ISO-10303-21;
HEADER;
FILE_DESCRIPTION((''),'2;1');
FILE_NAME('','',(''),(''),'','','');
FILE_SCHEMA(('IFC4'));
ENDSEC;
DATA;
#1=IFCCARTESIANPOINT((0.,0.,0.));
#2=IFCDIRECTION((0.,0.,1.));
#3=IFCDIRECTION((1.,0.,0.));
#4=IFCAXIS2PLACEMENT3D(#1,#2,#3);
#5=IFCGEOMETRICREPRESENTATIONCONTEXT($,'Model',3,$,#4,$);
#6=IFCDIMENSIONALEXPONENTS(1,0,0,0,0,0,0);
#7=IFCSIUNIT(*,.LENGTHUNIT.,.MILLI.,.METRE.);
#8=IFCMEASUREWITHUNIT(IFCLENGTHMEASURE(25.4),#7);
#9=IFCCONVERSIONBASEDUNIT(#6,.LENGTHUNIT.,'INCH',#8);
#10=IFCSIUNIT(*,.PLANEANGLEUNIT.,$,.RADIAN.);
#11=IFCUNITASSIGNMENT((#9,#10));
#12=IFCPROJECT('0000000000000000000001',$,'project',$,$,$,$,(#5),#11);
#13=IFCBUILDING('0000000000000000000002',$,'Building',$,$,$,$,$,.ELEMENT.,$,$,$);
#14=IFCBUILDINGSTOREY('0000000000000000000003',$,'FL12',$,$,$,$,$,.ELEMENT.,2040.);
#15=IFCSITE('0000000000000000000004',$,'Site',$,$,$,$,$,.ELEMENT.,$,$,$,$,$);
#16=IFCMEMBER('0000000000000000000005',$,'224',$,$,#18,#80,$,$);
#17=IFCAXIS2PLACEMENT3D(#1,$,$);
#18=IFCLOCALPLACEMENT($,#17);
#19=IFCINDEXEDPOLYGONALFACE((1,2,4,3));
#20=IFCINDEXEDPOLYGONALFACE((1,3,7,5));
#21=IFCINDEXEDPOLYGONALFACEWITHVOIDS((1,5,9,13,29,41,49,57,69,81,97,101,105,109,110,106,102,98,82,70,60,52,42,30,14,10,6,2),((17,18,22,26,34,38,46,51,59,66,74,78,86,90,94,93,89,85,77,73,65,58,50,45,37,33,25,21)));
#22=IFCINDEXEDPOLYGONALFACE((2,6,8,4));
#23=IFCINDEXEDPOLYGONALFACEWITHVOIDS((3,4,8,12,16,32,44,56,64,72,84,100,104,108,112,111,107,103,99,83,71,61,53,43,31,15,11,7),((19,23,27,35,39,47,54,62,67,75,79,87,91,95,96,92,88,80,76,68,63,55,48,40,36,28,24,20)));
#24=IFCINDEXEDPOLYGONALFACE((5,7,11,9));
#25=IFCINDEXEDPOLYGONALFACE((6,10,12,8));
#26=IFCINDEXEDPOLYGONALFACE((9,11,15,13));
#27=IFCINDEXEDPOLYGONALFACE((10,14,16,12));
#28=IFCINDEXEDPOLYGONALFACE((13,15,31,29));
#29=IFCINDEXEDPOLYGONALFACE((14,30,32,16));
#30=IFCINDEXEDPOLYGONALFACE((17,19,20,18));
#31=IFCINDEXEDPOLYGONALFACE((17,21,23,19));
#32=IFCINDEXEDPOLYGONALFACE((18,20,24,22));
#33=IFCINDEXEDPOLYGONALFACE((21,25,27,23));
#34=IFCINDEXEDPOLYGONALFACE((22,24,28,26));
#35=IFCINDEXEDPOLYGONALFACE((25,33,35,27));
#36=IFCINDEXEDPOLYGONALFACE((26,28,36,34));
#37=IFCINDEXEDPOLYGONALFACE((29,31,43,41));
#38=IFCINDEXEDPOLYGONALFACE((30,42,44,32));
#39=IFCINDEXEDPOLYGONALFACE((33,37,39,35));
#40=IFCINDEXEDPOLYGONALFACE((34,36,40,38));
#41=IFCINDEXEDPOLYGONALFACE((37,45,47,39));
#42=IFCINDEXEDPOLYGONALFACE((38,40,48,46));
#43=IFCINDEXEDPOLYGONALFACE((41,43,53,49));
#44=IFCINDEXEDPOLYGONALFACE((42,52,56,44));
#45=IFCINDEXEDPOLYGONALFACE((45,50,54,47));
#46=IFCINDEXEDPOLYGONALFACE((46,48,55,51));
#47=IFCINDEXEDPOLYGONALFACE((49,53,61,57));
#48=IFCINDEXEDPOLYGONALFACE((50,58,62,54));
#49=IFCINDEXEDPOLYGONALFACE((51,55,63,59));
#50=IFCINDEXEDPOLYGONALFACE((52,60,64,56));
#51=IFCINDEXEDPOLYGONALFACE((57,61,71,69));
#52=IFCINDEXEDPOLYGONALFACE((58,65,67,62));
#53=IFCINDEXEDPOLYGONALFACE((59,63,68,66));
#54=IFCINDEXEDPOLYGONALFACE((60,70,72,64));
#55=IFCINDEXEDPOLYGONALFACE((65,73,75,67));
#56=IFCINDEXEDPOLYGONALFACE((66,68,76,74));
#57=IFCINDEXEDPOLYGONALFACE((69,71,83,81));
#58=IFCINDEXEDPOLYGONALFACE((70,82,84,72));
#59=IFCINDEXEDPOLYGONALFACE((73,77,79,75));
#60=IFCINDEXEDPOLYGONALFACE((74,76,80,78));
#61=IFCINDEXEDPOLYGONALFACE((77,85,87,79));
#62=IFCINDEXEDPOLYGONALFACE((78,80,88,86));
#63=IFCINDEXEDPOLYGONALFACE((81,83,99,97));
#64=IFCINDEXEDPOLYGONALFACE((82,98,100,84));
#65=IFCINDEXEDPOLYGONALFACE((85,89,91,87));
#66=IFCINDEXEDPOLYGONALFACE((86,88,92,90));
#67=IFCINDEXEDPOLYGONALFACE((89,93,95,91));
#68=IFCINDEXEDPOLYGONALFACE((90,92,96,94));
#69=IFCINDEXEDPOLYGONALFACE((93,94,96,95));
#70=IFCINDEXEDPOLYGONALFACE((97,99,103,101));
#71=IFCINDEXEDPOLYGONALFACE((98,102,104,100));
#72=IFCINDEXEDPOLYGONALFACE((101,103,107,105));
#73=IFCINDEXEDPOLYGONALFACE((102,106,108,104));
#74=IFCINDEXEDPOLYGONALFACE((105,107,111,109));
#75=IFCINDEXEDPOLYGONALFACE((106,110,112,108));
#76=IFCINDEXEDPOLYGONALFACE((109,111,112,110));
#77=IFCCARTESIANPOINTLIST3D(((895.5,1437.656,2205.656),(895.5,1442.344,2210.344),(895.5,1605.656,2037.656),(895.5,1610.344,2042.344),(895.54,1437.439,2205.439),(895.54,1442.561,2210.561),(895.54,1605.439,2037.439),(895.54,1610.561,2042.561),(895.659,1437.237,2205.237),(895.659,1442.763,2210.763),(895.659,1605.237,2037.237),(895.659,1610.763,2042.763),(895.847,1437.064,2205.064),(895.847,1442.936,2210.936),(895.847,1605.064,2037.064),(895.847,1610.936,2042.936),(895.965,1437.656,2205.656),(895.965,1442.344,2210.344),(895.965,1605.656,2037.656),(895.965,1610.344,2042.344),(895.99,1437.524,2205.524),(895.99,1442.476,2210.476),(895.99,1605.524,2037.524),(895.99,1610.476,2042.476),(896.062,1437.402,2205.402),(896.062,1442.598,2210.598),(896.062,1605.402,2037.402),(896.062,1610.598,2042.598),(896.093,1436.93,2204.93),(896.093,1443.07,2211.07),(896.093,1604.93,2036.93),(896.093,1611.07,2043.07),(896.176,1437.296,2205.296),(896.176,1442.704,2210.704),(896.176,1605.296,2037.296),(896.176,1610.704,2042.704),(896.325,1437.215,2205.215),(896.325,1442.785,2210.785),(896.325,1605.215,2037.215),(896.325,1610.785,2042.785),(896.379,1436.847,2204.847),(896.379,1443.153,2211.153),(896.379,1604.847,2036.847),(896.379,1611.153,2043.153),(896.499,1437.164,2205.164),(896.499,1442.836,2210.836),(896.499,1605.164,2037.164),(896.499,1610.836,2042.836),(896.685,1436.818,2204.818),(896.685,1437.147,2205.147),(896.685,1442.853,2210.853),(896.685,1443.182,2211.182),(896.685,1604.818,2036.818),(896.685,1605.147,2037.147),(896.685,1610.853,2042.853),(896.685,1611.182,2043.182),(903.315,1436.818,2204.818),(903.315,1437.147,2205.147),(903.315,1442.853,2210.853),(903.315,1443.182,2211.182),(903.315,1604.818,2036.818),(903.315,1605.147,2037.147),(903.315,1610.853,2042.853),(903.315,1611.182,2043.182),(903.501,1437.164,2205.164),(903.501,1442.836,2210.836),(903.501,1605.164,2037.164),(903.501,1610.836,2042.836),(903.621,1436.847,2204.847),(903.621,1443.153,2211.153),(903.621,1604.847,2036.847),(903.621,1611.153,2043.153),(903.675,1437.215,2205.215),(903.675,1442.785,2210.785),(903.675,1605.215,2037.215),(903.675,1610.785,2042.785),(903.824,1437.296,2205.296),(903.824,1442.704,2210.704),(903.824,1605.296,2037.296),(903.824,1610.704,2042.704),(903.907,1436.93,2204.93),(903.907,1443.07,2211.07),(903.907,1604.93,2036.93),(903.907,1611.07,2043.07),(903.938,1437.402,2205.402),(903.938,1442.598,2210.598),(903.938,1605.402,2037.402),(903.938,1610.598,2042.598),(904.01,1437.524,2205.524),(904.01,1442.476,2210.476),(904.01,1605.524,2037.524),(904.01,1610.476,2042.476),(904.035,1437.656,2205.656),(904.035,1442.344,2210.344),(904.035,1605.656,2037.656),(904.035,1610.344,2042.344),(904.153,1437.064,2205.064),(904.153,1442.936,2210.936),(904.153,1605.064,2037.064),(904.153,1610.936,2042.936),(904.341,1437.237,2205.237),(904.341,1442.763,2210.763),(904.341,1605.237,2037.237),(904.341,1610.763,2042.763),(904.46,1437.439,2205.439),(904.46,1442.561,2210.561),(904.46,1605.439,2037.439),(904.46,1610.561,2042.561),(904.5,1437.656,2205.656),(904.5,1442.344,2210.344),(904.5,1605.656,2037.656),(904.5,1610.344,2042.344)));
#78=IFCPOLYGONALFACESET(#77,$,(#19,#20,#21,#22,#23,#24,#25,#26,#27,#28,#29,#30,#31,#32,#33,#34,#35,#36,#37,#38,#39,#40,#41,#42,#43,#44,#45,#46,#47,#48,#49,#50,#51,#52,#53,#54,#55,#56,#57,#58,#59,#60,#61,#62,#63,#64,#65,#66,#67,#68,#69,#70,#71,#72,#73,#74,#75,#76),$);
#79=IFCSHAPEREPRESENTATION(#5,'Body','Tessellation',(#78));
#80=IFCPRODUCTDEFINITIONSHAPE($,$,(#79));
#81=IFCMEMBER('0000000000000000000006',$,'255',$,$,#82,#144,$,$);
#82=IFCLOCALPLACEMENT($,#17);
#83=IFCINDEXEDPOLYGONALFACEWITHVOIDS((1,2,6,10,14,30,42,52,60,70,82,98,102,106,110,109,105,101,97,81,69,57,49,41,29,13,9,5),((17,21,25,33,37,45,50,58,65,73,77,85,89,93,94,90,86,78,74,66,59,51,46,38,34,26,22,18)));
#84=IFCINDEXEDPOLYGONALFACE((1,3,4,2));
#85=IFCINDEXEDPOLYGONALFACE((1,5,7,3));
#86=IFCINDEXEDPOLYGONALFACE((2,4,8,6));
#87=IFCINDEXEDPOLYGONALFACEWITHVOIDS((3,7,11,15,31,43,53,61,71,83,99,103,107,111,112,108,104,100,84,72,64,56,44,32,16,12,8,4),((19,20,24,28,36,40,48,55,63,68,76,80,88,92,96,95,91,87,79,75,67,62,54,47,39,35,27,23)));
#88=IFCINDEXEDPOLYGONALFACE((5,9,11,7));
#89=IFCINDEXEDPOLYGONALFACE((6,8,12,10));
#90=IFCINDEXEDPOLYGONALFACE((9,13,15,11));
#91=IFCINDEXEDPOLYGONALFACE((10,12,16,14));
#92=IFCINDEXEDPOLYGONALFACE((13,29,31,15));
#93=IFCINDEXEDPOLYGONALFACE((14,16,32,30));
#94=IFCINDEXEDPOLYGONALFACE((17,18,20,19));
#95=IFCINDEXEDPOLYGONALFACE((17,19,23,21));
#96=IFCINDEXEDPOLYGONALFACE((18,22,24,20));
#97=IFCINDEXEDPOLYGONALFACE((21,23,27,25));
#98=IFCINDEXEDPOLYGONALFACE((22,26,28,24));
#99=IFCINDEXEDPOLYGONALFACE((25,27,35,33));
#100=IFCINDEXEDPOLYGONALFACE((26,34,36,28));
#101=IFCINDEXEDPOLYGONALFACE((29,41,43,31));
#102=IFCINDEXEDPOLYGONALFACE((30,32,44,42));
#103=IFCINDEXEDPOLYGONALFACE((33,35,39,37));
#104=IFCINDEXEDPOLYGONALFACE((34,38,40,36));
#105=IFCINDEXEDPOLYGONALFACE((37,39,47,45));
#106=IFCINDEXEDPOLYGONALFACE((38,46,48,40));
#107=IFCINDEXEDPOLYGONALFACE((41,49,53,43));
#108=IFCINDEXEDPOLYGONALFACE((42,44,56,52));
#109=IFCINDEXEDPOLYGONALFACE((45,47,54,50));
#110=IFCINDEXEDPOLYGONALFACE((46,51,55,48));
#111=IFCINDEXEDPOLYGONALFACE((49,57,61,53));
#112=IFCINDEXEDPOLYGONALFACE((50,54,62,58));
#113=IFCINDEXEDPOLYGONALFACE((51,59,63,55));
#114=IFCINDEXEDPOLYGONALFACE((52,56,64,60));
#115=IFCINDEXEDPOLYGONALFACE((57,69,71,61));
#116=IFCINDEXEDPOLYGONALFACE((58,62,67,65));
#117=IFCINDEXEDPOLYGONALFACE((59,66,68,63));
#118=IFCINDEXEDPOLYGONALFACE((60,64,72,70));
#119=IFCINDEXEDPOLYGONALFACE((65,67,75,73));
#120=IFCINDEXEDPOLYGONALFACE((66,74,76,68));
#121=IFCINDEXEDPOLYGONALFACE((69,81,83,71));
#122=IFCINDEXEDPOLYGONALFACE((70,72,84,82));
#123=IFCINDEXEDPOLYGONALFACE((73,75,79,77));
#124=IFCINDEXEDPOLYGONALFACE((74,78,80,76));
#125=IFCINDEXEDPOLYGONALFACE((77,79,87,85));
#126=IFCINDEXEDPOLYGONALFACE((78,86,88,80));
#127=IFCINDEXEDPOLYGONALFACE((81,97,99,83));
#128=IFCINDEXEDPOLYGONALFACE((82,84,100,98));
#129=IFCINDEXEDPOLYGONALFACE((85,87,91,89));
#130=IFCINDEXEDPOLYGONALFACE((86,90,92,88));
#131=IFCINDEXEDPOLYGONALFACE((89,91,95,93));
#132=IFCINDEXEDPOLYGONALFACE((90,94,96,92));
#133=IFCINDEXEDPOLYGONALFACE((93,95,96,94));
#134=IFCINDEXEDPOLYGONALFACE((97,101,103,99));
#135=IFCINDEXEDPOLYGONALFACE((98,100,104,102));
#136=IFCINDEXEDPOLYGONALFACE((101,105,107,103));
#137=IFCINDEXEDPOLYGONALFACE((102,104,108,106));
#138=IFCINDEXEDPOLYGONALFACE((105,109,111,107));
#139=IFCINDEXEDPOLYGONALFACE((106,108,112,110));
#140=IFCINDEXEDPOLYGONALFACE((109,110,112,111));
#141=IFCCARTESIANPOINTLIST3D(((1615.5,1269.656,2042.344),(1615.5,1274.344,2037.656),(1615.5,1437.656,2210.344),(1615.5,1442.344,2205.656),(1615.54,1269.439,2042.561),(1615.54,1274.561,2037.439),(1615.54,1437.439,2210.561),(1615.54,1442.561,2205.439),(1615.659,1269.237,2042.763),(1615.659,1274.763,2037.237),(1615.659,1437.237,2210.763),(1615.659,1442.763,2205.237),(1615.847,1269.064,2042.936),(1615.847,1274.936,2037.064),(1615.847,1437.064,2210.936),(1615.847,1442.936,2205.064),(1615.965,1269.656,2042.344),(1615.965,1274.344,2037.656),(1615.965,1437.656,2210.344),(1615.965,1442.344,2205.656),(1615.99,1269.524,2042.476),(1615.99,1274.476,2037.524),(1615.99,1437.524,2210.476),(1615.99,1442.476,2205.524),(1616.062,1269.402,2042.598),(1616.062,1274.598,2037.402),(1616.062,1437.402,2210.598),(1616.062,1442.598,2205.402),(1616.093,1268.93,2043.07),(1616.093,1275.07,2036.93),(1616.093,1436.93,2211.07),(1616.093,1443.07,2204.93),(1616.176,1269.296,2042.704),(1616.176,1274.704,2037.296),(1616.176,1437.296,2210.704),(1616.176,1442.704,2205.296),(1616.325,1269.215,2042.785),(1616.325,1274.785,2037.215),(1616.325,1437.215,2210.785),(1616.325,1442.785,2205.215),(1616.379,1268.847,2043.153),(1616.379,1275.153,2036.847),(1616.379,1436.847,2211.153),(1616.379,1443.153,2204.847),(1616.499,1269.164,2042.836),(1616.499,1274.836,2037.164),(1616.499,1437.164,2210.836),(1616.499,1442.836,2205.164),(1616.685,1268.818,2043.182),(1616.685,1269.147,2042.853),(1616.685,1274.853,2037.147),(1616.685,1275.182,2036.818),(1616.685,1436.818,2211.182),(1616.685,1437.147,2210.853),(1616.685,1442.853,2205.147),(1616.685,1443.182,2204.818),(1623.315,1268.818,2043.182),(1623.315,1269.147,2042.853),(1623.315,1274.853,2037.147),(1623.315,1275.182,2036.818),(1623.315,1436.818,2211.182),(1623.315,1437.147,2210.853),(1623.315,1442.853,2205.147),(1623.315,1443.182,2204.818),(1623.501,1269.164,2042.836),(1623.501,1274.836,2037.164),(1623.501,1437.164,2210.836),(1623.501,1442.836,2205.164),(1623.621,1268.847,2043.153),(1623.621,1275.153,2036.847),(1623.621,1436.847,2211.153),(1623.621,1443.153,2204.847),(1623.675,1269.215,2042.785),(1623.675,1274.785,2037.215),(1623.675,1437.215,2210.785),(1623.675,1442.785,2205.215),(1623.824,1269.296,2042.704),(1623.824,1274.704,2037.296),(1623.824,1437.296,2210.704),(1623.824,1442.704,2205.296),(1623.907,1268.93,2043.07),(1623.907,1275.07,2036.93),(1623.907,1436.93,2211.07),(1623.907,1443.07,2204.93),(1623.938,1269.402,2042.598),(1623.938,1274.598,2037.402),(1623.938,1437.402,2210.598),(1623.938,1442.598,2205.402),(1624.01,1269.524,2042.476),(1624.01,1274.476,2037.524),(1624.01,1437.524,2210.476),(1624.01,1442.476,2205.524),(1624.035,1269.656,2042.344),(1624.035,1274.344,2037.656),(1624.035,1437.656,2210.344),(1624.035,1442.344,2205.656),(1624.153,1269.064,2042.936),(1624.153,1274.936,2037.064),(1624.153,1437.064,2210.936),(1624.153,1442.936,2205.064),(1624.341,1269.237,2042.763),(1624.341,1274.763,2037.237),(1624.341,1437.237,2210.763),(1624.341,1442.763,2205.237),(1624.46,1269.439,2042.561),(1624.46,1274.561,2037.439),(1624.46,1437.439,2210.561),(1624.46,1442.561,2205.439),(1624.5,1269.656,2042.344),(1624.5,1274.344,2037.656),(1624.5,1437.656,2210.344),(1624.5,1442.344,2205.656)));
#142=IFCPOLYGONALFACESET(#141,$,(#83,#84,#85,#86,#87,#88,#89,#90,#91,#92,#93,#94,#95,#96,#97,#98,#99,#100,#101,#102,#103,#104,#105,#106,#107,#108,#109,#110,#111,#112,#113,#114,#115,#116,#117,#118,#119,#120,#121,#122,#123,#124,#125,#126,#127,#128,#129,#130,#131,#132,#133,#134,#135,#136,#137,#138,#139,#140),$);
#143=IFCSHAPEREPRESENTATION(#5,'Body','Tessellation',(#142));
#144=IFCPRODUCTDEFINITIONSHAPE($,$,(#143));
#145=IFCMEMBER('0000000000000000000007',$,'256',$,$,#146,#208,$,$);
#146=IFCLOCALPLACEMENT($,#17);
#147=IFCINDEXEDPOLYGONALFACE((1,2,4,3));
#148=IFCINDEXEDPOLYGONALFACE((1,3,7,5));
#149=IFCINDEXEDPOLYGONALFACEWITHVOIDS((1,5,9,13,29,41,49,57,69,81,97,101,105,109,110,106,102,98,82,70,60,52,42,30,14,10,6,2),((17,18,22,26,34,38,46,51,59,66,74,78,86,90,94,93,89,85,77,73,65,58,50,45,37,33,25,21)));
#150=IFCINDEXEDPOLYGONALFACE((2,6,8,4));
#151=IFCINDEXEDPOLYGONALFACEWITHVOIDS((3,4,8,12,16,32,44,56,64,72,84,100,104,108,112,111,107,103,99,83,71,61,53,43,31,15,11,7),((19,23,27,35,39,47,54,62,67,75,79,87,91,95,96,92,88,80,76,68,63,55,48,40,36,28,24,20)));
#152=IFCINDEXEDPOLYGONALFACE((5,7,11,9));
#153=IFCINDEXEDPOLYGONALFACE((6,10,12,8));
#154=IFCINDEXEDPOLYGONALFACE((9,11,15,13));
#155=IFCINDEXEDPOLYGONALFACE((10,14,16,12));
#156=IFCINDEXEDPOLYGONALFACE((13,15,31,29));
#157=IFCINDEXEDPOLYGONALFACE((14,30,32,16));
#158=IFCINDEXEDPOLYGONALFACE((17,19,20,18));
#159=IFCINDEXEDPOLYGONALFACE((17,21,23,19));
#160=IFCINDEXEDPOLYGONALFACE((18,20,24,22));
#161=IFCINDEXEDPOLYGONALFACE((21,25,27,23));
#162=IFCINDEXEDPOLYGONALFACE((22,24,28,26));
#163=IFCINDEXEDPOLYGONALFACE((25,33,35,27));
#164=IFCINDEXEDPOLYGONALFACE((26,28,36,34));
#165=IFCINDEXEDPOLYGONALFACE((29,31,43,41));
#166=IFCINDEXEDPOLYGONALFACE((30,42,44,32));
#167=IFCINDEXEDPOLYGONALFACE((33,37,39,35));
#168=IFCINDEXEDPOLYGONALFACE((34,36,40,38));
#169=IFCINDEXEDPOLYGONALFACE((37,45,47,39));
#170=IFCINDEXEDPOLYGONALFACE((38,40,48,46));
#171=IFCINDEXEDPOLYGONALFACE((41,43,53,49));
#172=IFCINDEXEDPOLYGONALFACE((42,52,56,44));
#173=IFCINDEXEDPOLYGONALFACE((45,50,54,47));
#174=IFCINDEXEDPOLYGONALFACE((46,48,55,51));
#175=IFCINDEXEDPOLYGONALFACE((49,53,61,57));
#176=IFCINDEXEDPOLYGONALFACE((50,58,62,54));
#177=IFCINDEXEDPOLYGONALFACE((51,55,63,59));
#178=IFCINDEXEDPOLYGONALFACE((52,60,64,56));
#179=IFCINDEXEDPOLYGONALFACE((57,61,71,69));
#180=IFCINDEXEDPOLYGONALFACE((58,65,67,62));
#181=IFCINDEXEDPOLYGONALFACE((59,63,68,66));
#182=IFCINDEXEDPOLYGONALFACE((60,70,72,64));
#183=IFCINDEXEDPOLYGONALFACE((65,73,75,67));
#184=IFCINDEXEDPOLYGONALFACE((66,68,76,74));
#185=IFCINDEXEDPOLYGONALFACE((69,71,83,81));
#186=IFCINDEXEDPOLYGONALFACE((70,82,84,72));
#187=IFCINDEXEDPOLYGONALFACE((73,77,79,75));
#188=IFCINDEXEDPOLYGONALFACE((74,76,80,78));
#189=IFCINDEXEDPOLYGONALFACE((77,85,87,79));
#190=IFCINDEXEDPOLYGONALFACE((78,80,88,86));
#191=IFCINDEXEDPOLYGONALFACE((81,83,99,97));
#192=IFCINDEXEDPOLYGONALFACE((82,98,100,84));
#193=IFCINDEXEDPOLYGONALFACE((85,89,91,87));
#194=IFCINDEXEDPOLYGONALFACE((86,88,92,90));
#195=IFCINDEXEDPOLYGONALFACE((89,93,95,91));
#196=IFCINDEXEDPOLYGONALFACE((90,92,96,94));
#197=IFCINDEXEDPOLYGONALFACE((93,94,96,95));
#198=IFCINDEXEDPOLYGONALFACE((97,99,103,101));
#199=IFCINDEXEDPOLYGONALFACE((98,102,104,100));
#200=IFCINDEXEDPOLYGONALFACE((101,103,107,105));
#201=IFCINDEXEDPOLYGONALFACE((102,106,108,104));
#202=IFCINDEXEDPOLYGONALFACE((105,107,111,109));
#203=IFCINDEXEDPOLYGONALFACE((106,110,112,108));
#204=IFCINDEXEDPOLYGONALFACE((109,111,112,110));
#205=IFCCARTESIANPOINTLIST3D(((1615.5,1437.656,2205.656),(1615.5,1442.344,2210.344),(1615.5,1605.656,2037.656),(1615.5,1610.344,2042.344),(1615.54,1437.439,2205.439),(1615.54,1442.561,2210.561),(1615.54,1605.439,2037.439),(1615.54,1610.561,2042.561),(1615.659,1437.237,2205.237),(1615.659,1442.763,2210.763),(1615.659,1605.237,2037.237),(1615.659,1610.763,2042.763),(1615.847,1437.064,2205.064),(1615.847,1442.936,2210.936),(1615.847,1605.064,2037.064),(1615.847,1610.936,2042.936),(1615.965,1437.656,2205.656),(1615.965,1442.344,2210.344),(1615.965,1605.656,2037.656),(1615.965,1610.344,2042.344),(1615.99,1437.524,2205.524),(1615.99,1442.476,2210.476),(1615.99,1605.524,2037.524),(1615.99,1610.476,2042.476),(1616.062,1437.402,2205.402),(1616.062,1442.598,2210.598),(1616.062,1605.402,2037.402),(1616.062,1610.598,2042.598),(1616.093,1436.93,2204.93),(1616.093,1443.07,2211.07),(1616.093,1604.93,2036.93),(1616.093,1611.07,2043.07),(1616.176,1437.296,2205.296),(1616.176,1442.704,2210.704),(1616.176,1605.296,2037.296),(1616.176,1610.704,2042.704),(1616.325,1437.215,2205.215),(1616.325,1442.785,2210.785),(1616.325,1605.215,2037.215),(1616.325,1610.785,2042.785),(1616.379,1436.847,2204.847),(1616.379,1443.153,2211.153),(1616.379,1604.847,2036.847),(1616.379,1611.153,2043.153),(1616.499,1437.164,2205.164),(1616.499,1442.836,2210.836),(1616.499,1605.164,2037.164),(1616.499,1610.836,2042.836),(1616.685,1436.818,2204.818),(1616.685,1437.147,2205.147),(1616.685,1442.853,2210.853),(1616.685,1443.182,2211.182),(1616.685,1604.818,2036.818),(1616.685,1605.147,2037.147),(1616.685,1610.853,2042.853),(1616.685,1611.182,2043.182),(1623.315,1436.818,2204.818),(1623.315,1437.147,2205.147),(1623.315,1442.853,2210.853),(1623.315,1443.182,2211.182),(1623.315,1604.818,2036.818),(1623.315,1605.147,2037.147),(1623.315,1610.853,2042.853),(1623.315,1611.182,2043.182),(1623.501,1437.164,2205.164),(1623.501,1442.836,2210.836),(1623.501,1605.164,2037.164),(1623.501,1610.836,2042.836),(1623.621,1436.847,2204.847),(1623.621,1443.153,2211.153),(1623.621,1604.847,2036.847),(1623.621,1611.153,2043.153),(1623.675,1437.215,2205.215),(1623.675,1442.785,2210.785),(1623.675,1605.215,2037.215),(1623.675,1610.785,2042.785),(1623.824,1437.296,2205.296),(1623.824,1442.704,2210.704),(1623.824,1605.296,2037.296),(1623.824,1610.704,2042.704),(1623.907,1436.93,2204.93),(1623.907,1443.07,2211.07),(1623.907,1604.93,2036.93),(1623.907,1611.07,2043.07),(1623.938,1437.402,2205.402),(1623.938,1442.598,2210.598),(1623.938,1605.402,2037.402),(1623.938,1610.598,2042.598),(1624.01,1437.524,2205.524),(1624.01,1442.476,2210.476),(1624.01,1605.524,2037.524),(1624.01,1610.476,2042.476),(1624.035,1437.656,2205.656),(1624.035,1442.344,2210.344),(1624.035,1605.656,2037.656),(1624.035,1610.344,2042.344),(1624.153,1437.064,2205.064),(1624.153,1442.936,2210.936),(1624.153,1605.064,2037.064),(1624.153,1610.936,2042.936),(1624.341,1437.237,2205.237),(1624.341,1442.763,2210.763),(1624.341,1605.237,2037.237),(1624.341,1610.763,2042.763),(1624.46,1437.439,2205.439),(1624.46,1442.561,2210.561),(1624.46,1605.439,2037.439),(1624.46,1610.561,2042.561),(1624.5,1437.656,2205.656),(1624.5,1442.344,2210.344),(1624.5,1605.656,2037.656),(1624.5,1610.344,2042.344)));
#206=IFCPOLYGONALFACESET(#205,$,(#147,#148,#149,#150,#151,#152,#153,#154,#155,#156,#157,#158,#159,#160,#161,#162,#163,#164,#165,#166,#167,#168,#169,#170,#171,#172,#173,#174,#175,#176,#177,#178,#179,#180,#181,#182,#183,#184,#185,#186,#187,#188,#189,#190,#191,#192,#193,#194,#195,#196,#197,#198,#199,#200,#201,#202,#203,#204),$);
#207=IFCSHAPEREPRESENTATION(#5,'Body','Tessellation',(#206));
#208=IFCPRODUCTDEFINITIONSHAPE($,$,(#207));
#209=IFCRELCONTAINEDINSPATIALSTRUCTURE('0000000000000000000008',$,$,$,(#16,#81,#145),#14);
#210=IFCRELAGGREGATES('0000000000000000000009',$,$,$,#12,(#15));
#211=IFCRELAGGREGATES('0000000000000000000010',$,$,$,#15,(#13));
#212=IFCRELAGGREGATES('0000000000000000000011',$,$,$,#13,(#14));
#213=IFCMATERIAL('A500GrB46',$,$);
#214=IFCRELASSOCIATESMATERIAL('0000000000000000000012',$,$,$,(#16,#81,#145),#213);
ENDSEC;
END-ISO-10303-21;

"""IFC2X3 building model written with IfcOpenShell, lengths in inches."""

from ifc_helpers import new_model, entity, si_unit, converted_unit, frame, origin_with_axes, origin_2d_with_axis, place, context, project, spatial, hollow_rectangle, extrude, material, element, save


model = new_model("IFC2X3")

# Units and contexts
model_context = context("Model", 3, world=origin_with_axes())
ifc_project = project(units=[converted_unit("LENGTHUNIT", "INCH", entity("IfcLengthMeasure", 25.4), si_unit("LENGTHUNIT", "METRE", prefix="MILLI"), dimensions=[1, 0, 0, 0, 0, 0, 0]), si_unit("PLANEANGLEUNIT", "RADIAN")], contexts=[model_context])

# Site, building, storey
site = spatial("IfcSite", under=ifc_project, Name="Site", CompositionType="ELEMENT")
building = spatial("IfcBuilding", under=site, Name="Building", CompositionType="ELEMENT")
storey = spatial("IfcBuildingStorey", under=building, Name="FL12", CompositionType="ELEMENT", Elevation=2040.0)

# Members
ifc_material_1 = material(Name="A500GrB46")
for number, where, z_axis, x_axis, name in (
    (1, (900.0, 1608.0, 2040.0), (0.0, -0.707107, 0.707107), (1.0, 0.0, 0.0), "224"),
    (2, (1620.0, 1272.0, 2040.0), (0.0, 0.707107, 0.707107), (-1.0, 0.0, 0.0), "255"),
    (3, (1620.0, 1608.0, 2040.0), (0.0, -0.707107, 0.707107), (1.0, 0.0, 0.0), "256"),
):
    element("IfcMember", number, at=place(None, frame(where, z_axis=z_axis, x_axis=x_axis)), inside=storey, material=ifc_material_1, Name=name, context=model_context, shape_type="SweptSolid", body=[
        extrude(hollow_rectangle(XDim=9.0, YDim=9.0, WallThickness=0.465, InnerFilletRadius=0.72, OuterFilletRadius=1.185, at=origin_2d_with_axis()), origin_with_axes(), (0.0, 0.0, 1.0), 237.588),
    ])

save(model, "model.ifc")
